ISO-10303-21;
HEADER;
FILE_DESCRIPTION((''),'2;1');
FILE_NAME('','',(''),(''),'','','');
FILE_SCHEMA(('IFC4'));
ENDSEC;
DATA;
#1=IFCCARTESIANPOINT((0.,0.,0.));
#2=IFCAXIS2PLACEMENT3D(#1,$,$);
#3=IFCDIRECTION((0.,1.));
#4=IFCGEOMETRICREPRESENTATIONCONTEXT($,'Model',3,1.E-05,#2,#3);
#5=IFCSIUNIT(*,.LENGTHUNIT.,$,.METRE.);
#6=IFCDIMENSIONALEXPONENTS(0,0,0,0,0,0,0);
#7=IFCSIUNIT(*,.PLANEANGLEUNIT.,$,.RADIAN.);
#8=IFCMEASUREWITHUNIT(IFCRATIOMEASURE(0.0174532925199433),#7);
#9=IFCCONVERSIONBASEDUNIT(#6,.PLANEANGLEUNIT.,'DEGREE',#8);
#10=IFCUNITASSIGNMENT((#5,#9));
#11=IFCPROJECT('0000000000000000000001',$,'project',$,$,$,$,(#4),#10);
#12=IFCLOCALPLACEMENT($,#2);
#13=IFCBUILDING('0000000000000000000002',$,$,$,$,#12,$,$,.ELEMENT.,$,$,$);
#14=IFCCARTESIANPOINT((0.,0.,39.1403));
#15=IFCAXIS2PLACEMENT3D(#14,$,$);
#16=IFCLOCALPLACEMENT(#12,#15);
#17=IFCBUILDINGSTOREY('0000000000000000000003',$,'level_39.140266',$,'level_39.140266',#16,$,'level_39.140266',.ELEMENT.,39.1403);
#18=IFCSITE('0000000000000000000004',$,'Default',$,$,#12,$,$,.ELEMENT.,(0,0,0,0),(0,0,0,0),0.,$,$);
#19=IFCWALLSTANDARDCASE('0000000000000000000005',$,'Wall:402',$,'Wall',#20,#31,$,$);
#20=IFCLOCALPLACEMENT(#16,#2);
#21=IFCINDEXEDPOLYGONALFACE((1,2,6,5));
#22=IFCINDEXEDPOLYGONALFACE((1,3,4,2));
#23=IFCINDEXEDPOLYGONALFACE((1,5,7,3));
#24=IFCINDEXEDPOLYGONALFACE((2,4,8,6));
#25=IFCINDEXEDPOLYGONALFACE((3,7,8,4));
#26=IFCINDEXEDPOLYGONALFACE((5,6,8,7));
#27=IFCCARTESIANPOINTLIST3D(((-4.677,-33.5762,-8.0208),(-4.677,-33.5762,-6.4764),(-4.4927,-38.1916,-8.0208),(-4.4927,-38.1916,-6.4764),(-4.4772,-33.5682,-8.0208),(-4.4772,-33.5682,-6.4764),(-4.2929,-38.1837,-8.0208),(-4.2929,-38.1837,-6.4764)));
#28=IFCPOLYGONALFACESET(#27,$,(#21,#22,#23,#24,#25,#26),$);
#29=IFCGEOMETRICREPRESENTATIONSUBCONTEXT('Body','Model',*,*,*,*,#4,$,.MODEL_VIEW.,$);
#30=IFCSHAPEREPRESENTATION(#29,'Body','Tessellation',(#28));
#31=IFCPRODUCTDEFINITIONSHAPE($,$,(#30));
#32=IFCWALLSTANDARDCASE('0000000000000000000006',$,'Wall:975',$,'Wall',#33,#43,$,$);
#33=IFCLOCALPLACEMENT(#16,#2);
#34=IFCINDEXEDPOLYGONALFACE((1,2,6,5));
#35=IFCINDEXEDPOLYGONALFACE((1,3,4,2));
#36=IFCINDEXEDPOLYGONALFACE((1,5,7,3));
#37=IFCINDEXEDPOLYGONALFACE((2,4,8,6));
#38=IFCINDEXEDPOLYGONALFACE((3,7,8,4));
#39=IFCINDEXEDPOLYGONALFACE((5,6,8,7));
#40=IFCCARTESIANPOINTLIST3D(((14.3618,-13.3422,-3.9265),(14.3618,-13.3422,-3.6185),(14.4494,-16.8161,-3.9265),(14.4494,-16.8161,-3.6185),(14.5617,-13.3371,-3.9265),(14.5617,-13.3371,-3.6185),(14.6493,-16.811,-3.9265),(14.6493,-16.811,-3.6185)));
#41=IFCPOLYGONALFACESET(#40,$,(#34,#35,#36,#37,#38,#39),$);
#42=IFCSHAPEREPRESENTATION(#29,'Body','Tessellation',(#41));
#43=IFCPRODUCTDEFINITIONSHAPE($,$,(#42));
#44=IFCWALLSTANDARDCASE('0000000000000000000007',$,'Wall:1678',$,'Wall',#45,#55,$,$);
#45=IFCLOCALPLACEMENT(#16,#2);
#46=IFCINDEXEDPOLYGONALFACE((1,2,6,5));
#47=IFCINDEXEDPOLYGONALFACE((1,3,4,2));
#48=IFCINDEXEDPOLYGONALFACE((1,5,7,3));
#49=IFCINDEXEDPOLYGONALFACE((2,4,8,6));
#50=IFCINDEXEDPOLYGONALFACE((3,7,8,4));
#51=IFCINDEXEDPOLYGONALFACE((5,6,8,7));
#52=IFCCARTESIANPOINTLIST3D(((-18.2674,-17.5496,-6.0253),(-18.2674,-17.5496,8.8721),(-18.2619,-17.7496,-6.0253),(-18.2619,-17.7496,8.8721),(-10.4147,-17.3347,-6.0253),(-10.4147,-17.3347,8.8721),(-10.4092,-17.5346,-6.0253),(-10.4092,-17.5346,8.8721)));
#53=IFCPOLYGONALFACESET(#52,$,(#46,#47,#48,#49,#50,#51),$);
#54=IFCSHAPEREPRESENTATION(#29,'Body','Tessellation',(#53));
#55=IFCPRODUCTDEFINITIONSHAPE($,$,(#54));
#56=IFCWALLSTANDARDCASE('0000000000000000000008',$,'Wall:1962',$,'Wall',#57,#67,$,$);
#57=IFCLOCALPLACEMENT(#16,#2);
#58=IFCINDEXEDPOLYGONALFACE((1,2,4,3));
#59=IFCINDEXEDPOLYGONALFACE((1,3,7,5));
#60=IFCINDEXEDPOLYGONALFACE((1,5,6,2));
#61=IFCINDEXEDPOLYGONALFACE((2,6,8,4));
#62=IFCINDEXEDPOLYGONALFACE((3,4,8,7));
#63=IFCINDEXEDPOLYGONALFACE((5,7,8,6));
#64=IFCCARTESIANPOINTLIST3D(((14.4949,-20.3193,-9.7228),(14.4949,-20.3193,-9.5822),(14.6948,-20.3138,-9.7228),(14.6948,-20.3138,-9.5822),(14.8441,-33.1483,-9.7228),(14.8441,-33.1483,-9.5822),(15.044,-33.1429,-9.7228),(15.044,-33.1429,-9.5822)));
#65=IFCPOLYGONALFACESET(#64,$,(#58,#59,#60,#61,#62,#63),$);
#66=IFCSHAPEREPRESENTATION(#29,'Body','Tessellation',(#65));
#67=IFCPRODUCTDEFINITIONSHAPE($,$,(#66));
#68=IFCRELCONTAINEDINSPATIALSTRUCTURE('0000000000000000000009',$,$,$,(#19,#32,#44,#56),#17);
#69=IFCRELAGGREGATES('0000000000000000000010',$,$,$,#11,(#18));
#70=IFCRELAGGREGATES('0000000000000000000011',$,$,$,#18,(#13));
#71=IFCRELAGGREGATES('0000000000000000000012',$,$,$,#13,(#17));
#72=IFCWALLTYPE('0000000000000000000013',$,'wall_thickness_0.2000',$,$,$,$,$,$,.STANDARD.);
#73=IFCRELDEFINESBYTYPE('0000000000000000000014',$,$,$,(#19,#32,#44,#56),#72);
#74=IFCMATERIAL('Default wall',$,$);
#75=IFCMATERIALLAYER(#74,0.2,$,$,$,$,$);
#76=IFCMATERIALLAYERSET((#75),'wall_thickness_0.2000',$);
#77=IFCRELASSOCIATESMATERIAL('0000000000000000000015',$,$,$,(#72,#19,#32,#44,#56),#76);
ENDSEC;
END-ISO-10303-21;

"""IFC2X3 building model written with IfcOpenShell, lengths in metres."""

from ifc_helpers import new_model, entity, si_unit, converted_unit, direction, frame, origin, place, context, subcontext, project, spatial, polyline, outline, extrude, material, layer, layer_set, layer_usage, type_object, element, save


model = new_model("IFC2X3")

# Units and contexts
model_context = context("Model", 3, precision=1e-05, world=origin(), true_north=direction((0.0, 1.0)))
body_context = subcontext(model_context, "Body", "Model", "MODEL_VIEW")
ifc_project = project(units=[si_unit("LENGTHUNIT", "METRE"), converted_unit("PLANEANGLEUNIT", "DEGREE", entity("IfcRatioMeasure", 0.0174532925199433), si_unit("PLANEANGLEUNIT", "RADIAN"), dimensions=[0, 0, 0, 0, 0, 0, 0])], contexts=[model_context])

# Site, building, storey
placement_1 = place(None, origin())
site = spatial("IfcSite", under=ifc_project, at=placement_1, Name="Default", CompositionType="ELEMENT", RefLatitude=(0, 0, 0, 0), RefLongitude=(0, 0, 0, 0), RefElevation=0.0)
building = spatial("IfcBuilding", under=site, at=placement_1, CompositionType="ELEMENT")
storey_placement = place(placement_1, frame((0.0, 0.0, 39.1403)))
storey = spatial("IfcBuildingStorey", under=building, at=storey_placement, Name="level_39.140266", ObjectType="level_39.140266", LongName="level_39.140266", CompositionType="ELEMENT", Elevation=39.1403)

# Walls
ifc_material = material(Name="Default wall")
ifc_layer = layer(ifc_material, 0.2)
ifc_layer_set = layer_set([ifc_layer], Name="wall_thickness_0.2000")
ifc_layer_usage = layer_usage(ifc_layer_set, "AXIS2", "POSITIVE", -0.1)
wall_type = type_object("IfcWallType", Name="wall_thickness_0.2000", PredefinedType="STANDARD", material=ifc_layer_set)
placement_2 = place(placement_1, frame((0.0, 0.0, 31.1195)))
wall_1_placement = place(placement_2, frame((-4.3928, -38.1877, 0.0), z_axis=(0.0, 0.0, 1.0), x_axis=(-0.039907, 0.999203, 0.0)))
element("IfcWallStandardCase", 1, at=wall_1_placement, inside=storey, type_object=wall_type, material=ifc_layer_usage, Name="Wall:402", ObjectType="Wall", context=body_context, shape_type="SweptSolid", body=[
    extrude(outline(polyline([(4.6192, -0.1), (4.6192, 0.1), (0.0, 0.1), (0.0, -0.1), (4.6192, -0.1)])), origin(), (0.0, 0.0, 1.0), 1.5444),
])
placement_3 = place(placement_1, frame((0.0, 0.0, 35.2138)))
wall_2_placement = place(placement_3, frame((14.4617, -13.3396, 0.0), z_axis=(0.0, 0.0, 1.0), x_axis=(0.025203, -0.999682, 0.0)))
element("IfcWallStandardCase", 2, at=wall_2_placement, inside=storey, type_object=wall_type, material=ifc_layer_usage, Name="Wall:975", ObjectType="Wall", context=body_context, shape_type="SweptSolid", body=[
    extrude(outline(polyline([(3.475, -0.1), (3.475, 0.1), (0.0, 0.1), (0.0, -0.1), (3.475, -0.1)])), origin(), (0.0, 0.0, 1.0), 0.308),
])
placement_4 = place(placement_1, frame((0.0, 0.0, 33.115)))
wall_3_placement = place(placement_4, frame((-10.4119, -17.4346, 0.0), z_axis=(0.0, 0.0, 1.0), x_axis=(-0.999625, -0.027366, 0.0)))
element("IfcWallStandardCase", 3, at=wall_3_placement, inside=storey, type_object=wall_type, material=ifc_layer_usage, Name="Wall:1678", ObjectType="Wall", context=body_context, shape_type="SweptSolid", body=[
    extrude(outline(polyline([(7.8556, -0.1), (7.8556, 0.1), (0.0, 0.1), (0.0, -0.1), (7.8556, -0.1)])), origin(), (0.0, 0.0, 1.0), 14.8974),
])
placement_5 = place(placement_1, frame((0.0, 0.0, 29.4175)))
wall_4_placement = place(placement_5, frame((14.5949, -20.3166, 0.0), z_axis=(0.0, 0.0, 1.0), x_axis=(0.027207, -0.99963, 0.0)))
element("IfcWallStandardCase", 4, at=wall_4_placement, inside=storey, type_object=wall_type, material=ifc_layer_usage, Name="Wall:1962", ObjectType="Wall", context=body_context, shape_type="SweptSolid", body=[
    extrude(outline(polyline([(12.8338, -0.1), (12.8338, 0.1), (0.0, 0.1), (0.0, -0.1), (12.8338, -0.1)])), origin(), (0.0, 0.0, 1.0), 0.1405),
])

save(model, "model.ifc")
